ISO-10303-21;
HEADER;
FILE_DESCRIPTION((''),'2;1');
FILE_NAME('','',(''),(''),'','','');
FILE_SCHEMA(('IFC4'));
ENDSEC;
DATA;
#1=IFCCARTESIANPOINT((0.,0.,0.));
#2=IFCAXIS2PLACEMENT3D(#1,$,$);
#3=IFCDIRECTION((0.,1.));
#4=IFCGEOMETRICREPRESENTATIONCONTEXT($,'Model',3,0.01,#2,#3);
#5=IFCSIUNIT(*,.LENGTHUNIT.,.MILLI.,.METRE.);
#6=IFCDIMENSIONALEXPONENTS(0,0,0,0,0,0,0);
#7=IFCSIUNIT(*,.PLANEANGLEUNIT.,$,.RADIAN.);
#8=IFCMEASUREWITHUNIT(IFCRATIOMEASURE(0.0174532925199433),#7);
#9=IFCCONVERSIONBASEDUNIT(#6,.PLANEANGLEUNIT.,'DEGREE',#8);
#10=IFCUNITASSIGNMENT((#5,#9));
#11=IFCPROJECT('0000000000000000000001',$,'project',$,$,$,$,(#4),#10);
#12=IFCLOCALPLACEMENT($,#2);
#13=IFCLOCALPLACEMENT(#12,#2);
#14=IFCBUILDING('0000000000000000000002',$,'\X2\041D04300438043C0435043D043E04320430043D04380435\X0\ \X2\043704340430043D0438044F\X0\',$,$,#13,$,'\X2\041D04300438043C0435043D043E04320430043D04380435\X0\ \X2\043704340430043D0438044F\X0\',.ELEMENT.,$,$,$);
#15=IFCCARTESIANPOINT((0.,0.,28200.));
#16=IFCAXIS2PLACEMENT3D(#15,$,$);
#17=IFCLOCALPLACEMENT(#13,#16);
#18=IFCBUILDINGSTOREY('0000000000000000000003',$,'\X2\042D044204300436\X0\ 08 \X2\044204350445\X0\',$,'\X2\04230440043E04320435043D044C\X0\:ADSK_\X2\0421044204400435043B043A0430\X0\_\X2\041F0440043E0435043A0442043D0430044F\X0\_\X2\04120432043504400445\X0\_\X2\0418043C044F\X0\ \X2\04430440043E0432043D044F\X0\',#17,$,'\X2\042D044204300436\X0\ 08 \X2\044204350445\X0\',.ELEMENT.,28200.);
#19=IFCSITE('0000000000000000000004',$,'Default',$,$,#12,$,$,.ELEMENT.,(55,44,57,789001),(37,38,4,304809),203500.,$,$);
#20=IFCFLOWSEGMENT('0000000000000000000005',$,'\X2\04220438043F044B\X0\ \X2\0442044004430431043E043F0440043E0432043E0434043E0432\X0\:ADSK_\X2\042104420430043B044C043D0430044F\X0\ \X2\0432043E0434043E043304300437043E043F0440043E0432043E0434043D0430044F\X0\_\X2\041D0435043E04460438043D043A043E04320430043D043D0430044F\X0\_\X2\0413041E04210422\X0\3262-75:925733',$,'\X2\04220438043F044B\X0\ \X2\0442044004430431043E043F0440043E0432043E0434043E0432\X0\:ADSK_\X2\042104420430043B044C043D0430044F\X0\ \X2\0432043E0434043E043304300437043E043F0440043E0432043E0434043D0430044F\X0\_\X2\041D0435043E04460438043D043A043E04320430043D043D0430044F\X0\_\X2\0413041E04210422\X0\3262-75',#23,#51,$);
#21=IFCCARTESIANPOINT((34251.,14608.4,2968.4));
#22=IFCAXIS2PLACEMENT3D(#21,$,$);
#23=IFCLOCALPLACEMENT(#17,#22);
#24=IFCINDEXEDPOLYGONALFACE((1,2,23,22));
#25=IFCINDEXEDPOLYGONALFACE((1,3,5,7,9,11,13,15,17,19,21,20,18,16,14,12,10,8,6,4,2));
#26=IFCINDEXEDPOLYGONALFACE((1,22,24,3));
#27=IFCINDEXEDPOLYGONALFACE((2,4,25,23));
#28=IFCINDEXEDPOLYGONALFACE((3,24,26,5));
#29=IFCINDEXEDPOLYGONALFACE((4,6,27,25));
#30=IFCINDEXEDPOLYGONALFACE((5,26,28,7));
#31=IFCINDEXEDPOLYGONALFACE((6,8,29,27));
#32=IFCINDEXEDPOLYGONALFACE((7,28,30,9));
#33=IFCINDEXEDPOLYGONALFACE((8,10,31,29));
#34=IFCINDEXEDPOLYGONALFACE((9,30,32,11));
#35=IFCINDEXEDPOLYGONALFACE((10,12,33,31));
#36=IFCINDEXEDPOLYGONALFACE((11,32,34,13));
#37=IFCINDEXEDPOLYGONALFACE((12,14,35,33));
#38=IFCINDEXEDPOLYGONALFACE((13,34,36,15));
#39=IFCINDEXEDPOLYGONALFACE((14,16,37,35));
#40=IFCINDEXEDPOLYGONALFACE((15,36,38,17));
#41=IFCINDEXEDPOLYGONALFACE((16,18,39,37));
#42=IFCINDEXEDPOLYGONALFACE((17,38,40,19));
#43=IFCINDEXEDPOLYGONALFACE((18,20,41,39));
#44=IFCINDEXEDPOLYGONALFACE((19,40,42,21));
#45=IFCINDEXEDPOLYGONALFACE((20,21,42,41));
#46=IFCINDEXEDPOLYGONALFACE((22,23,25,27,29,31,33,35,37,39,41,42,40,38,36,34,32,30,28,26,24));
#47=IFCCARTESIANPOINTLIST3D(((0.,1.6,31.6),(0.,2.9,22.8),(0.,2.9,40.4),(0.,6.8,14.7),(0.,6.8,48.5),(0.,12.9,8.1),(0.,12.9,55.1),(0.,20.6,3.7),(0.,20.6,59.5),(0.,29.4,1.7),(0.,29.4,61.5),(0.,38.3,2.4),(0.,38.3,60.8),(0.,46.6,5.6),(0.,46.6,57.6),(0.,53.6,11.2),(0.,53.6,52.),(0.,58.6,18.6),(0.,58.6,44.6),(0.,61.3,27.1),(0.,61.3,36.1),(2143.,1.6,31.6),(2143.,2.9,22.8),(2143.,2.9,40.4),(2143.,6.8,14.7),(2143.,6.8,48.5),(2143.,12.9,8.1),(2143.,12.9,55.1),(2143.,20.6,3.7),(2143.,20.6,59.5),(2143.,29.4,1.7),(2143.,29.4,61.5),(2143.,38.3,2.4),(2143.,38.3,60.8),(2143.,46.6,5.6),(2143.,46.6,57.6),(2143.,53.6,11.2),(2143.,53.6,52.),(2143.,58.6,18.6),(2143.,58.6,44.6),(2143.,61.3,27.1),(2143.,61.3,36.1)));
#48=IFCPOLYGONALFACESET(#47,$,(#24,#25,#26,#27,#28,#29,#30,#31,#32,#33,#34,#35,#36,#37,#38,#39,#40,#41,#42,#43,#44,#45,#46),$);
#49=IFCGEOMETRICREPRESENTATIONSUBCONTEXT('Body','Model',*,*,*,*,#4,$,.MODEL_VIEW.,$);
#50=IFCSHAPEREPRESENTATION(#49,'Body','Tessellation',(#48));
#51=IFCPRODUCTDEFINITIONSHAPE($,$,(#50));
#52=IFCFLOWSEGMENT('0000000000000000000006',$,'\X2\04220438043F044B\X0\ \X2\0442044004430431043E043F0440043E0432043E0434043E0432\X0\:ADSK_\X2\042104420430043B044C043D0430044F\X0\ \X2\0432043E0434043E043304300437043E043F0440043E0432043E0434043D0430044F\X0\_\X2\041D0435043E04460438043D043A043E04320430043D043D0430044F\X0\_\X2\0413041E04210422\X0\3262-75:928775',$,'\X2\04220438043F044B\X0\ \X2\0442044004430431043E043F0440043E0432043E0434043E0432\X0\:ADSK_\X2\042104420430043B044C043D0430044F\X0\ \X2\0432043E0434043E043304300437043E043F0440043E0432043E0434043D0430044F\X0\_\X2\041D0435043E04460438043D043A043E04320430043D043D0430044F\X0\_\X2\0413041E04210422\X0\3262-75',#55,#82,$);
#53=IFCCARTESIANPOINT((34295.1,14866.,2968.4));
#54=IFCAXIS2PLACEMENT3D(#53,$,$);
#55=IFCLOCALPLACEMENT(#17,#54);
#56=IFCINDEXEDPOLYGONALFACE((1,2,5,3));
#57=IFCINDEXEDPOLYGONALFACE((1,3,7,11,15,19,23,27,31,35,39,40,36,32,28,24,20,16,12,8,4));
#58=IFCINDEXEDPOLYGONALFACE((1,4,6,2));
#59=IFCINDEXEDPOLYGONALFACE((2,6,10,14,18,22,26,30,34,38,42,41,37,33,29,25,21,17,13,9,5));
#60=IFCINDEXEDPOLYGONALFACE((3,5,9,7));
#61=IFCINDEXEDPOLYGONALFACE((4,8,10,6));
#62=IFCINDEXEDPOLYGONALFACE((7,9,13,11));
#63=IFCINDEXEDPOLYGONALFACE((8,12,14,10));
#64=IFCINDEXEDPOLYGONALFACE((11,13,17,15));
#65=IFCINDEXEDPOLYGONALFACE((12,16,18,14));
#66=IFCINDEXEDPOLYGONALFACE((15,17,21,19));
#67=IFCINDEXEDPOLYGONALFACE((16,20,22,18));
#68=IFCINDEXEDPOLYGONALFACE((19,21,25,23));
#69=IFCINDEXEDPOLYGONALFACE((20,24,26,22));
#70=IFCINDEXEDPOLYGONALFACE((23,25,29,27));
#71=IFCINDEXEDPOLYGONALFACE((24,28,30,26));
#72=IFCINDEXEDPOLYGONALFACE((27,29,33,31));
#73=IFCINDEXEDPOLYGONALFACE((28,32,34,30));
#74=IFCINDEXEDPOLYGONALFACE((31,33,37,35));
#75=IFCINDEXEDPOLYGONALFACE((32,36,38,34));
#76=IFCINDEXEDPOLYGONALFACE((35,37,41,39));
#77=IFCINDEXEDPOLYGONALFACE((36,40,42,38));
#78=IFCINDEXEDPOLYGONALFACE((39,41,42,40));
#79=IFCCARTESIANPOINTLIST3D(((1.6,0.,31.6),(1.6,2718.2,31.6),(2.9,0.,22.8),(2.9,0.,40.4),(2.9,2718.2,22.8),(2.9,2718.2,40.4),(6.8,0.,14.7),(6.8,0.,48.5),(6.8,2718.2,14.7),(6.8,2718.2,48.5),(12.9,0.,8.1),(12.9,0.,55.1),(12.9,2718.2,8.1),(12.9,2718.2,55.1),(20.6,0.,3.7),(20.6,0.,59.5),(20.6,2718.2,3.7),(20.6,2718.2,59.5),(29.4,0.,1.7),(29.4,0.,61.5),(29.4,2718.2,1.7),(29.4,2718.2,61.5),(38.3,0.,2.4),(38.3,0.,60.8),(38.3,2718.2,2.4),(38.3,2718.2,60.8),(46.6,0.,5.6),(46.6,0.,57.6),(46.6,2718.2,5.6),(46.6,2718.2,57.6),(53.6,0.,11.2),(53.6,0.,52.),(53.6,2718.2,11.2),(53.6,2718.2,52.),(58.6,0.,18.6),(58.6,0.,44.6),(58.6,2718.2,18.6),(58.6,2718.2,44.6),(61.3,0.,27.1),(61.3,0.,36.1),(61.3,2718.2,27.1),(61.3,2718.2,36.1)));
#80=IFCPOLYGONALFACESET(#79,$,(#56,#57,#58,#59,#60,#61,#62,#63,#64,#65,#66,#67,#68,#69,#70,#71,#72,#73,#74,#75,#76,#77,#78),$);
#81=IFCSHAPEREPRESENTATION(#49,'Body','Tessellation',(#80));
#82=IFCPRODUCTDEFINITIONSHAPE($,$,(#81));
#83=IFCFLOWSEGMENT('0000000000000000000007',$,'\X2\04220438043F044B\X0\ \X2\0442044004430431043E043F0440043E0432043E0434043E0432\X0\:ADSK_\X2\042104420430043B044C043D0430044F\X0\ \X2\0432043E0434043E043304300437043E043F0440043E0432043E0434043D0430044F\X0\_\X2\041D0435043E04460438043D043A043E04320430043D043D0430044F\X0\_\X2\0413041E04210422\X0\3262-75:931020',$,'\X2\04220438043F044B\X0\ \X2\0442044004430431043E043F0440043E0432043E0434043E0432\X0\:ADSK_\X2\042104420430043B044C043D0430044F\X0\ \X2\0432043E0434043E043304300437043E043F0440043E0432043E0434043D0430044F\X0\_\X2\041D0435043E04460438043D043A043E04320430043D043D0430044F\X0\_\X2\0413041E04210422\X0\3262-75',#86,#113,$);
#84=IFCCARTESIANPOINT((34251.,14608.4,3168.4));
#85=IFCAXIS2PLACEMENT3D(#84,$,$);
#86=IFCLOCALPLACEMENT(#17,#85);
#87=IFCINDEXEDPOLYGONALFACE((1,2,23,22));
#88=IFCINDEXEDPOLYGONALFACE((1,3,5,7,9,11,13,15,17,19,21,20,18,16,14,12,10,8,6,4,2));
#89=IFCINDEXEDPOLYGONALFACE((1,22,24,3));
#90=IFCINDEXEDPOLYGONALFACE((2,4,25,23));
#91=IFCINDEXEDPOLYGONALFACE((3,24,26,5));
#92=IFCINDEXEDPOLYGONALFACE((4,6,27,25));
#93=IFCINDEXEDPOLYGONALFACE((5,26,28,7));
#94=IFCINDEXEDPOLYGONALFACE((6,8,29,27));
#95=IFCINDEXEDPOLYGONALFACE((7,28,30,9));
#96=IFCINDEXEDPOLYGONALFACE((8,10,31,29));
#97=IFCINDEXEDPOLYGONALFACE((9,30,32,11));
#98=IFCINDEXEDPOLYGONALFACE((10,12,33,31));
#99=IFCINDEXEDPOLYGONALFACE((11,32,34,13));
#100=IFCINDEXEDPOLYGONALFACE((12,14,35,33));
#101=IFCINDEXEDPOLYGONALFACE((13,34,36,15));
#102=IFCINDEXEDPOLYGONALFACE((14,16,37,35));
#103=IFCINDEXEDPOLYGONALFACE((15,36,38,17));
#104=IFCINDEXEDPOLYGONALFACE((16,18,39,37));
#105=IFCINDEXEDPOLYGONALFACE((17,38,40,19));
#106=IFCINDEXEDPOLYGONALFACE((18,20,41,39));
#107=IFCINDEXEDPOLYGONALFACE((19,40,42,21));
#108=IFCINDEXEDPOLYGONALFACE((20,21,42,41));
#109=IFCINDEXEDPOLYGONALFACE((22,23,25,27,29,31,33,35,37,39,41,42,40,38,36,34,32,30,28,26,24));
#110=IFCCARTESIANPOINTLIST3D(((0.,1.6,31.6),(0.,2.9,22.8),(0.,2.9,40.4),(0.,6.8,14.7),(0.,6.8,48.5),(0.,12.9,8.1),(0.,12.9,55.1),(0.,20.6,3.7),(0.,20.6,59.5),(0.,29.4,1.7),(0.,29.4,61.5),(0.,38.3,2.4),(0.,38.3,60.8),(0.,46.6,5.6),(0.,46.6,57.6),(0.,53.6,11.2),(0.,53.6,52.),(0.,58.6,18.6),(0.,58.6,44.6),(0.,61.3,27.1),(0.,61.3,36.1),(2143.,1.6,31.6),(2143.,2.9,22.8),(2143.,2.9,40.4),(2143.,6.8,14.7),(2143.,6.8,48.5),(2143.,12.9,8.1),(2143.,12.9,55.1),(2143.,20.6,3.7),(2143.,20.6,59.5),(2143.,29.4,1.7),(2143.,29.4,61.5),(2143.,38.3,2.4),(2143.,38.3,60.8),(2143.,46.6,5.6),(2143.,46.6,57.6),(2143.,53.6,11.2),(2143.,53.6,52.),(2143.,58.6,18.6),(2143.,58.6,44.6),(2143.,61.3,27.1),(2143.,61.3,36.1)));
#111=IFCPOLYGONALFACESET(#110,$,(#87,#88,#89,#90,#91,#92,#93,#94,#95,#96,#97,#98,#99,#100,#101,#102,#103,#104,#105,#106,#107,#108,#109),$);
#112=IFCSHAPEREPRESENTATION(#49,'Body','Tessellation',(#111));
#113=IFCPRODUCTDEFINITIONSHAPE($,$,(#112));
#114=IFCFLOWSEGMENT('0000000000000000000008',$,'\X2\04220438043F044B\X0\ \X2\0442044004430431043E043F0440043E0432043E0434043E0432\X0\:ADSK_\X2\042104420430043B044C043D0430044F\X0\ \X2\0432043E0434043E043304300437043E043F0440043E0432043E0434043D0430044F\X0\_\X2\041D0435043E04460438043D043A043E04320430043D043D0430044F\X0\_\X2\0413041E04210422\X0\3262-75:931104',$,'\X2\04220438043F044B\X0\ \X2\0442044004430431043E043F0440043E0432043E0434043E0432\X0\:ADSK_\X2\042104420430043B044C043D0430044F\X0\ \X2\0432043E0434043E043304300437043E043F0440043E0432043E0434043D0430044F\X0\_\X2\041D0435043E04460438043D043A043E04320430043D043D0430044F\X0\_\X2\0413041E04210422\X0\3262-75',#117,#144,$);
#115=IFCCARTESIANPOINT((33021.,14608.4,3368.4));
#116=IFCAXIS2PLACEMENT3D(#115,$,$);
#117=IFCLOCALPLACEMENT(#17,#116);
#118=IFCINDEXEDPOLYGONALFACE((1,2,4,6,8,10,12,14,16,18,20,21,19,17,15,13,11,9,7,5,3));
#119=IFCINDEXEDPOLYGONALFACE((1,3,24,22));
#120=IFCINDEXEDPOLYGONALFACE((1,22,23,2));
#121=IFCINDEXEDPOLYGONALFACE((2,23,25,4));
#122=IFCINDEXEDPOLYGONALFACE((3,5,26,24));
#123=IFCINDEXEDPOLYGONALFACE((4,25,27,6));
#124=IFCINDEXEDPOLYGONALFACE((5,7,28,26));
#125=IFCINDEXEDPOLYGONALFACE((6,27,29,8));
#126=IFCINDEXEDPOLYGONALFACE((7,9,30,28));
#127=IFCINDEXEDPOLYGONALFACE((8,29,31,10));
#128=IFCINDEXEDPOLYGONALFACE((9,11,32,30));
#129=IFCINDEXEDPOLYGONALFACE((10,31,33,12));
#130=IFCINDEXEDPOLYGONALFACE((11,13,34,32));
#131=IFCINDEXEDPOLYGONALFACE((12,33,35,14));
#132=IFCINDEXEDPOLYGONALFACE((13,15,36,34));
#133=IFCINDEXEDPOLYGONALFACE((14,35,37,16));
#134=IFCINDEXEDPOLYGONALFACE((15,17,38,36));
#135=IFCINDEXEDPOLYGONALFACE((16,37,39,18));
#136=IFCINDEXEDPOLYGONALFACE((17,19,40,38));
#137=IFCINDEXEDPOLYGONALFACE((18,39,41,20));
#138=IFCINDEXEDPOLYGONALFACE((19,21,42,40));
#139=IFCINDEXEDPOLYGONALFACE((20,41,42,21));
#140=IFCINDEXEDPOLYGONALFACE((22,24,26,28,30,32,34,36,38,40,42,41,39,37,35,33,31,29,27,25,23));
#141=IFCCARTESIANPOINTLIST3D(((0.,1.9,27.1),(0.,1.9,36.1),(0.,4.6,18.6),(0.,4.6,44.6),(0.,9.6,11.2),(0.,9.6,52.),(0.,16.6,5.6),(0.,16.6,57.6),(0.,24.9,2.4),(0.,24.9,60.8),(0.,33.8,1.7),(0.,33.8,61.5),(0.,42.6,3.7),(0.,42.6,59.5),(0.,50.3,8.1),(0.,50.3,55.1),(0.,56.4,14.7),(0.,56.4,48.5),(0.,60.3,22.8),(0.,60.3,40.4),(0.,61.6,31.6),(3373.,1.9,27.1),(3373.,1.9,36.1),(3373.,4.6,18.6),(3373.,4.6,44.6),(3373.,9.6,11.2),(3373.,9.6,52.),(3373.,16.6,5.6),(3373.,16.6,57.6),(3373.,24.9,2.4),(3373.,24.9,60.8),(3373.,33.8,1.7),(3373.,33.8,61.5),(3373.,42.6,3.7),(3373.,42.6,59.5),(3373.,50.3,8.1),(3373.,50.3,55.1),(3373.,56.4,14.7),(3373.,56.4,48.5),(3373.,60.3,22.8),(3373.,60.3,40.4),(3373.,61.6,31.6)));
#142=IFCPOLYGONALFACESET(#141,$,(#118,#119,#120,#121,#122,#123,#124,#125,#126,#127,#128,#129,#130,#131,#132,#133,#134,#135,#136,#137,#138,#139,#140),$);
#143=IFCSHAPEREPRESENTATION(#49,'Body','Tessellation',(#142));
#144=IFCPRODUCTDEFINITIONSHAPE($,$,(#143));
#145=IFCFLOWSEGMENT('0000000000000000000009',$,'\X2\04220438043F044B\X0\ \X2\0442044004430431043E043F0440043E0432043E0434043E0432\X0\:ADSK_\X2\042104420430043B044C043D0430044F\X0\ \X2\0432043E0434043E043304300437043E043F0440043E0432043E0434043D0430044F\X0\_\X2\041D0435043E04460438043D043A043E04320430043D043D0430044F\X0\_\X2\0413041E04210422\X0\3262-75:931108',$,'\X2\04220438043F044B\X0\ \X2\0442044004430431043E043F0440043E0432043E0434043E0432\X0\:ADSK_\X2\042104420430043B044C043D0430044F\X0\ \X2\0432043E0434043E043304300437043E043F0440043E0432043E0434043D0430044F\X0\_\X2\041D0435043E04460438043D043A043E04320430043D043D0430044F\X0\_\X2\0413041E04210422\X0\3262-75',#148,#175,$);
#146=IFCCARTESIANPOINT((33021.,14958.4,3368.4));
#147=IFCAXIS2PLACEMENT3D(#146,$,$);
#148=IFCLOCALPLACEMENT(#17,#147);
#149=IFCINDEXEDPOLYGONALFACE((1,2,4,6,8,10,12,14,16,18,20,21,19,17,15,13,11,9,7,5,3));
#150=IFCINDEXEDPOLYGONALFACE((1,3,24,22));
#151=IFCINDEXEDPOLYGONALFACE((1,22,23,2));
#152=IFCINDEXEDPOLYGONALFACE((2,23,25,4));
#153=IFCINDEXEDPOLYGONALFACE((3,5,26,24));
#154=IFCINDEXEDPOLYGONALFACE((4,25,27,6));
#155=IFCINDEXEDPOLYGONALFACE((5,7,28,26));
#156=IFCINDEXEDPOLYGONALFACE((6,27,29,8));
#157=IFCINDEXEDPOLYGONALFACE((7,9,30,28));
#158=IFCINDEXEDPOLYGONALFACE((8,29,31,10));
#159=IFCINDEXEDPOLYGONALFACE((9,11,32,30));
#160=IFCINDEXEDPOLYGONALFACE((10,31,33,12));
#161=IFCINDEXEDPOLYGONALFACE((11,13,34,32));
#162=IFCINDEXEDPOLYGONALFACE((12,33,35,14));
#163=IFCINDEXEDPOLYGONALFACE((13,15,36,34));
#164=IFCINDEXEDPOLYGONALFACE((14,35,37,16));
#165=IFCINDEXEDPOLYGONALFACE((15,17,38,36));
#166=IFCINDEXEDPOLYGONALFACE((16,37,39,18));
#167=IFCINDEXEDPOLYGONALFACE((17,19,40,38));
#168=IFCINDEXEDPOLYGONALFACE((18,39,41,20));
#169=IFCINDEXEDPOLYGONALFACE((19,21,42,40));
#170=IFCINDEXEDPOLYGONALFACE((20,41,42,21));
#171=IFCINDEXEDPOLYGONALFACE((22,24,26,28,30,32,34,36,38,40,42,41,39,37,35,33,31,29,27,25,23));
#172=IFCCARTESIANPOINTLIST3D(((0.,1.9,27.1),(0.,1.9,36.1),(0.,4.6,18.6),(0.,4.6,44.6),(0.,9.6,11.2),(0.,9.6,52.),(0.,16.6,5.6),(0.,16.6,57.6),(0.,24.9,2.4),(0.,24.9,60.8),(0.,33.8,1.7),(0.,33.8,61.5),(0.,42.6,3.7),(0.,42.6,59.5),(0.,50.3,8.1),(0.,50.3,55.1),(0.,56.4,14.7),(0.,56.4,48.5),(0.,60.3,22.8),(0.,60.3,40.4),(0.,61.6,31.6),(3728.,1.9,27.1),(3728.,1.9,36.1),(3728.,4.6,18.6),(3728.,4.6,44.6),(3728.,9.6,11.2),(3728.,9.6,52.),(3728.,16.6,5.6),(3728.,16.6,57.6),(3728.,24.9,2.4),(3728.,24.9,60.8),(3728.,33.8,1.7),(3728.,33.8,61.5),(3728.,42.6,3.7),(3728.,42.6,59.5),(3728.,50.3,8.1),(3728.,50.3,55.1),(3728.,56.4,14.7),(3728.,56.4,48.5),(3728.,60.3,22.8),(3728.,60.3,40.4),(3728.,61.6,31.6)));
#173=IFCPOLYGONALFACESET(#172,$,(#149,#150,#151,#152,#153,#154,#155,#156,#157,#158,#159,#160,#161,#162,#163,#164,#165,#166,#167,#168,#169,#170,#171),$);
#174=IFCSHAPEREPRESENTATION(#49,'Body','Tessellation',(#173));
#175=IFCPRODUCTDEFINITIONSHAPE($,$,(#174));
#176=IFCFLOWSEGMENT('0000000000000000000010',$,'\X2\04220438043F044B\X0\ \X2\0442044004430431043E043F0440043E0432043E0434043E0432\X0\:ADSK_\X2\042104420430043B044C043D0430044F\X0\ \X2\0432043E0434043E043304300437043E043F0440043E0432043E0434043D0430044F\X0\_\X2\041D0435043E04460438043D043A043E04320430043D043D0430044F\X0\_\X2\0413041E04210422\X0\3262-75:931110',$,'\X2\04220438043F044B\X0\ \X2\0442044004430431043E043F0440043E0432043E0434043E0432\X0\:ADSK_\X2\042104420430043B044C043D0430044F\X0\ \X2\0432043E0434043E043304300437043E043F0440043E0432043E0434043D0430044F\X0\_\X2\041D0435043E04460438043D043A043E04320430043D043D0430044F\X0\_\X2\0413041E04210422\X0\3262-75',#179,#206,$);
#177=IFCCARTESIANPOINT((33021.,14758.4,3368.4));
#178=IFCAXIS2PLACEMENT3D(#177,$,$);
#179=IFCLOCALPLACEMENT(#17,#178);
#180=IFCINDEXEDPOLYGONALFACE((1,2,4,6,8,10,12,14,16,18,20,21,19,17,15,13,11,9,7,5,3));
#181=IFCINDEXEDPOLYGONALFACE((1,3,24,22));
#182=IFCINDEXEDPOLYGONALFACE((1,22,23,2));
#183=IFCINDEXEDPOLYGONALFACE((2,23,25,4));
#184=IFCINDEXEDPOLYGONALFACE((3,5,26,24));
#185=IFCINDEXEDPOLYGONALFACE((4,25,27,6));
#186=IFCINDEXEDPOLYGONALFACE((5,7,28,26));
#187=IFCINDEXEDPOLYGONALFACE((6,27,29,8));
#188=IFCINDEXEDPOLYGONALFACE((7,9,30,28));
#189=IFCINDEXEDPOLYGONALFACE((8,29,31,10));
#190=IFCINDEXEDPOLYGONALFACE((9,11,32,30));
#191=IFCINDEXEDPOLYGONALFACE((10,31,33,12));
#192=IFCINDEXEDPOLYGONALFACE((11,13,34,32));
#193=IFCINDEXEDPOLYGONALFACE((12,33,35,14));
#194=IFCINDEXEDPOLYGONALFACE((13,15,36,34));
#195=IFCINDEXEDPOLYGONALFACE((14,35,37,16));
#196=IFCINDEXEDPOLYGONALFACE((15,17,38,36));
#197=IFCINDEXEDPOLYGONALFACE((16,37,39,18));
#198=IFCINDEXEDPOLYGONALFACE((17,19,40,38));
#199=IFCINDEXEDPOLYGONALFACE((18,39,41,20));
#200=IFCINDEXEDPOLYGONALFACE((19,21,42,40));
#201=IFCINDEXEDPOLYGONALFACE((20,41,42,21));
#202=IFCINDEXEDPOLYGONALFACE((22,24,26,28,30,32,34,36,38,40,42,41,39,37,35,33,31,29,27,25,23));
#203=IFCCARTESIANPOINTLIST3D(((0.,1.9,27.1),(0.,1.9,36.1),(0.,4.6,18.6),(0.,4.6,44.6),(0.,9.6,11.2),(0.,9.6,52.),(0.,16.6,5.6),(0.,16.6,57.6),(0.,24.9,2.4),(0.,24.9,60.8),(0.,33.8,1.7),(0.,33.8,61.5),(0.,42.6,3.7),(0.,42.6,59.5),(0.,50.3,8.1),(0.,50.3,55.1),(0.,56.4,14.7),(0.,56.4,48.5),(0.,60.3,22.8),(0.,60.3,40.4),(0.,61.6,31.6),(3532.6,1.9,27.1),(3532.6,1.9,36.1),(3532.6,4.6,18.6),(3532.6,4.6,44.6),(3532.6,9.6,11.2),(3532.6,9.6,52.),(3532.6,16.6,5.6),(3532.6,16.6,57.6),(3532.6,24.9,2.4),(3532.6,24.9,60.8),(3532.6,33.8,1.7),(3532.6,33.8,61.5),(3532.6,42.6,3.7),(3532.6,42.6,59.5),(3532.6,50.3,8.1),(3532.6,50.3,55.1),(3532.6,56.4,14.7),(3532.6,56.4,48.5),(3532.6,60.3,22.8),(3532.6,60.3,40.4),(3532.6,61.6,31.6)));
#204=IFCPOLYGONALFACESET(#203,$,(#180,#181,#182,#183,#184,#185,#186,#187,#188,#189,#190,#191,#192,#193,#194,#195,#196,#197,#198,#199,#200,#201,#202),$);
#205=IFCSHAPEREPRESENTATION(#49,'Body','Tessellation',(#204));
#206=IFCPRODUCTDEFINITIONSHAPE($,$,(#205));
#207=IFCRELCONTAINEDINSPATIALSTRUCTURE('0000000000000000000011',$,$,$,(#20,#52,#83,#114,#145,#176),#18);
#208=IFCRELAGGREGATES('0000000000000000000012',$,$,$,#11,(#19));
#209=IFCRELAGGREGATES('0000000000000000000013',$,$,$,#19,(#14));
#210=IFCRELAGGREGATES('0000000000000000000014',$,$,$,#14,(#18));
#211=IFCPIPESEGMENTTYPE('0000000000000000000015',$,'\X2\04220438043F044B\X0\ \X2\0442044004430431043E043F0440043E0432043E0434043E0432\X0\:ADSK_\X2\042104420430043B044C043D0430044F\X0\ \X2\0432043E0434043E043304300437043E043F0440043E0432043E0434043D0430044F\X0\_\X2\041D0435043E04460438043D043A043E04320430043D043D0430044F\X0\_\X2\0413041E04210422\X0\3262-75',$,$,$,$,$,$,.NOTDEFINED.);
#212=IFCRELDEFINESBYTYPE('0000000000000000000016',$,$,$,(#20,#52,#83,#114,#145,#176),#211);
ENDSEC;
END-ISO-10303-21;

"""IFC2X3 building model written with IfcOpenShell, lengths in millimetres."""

from ifc_helpers import new_model, entity, si_unit, converted_unit, direction, frame, origin, origin_2d_with_axis, place, context, subcontext, project, spatial, circle, extrude, type_object, element, save


model = new_model("IFC2X3")

# Units and contexts
model_context = context("Model", 3, precision=0.01, world=origin(), true_north=direction((0.0, 1.0)))
body_context = subcontext(model_context, "Body", "Model", "MODEL_VIEW")
ifc_project = project(units=[si_unit("LENGTHUNIT", "METRE", prefix="MILLI"), converted_unit("PLANEANGLEUNIT", "DEGREE", entity("IfcRatioMeasure", 0.0174532925199433), si_unit("PLANEANGLEUNIT", "RADIAN"), dimensions=[0, 0, 0, 0, 0, 0, 0])], contexts=[model_context])

# Site, building, storey
site_placement = place(None, origin())
site = spatial("IfcSite", under=ifc_project, at=site_placement, Name="Default", CompositionType="ELEMENT", RefLatitude=(55, 44, 57, 789001), RefLongitude=(37, 38, 4, 304809), RefElevation=203500.0)
building_placement = place(site_placement, origin())
building = spatial("IfcBuilding", under=site, at=building_placement, Name="Наименование здания", LongName="Наименование здания", CompositionType="ELEMENT")
storey_placement = place(building_placement, frame((0.0, 0.0, 28200.0)))
storey = spatial("IfcBuildingStorey", under=building, at=storey_placement, Name="Этаж 08 тех", ObjectType="Уровень:ADSK_Стрелка_Проектная_Вверх_Имя уровня", LongName="Этаж 08 тех", CompositionType="ELEMENT", Elevation=28200.0)

# Flow segments
pipe_segment_type = type_object("IfcPipeSegmentType", Name="Типы трубопроводов:ADSK_Стальная водогазопроводная_Неоцинкованная_ГОСТ3262-75", PredefinedType="NOTDEFINED")
flow_segment_1_placement = place(storey_placement, frame((34251.0, 14608.4, 2968.4)))
element("IfcFlowSegment", 1, at=flow_segment_1_placement, inside=storey, type_object=pipe_segment_type, Name="Типы трубопроводов:ADSK_Стальная водогазопроводная_Неоцинкованная_ГОСТ3262-75:925733", ObjectType="Типы трубопроводов:ADSK_Стальная водогазопроводная_Неоцинкованная_ГОСТ3262-75", context=body_context, shape_type="SweptSolid", body=[
    extrude(circle(Radius=30.0, at=origin_2d_with_axis()), frame((0.0, 31.6, 31.6), z_axis=(1.0, 0.0, 0.0), x_axis=(0.0, -1.0, 0.0)), (0.0, 0.0, 1.0), 2143.0),
])
flow_segment_2_placement = place(storey_placement, frame((34295.1, 14866.0, 2968.4)))
element("IfcFlowSegment", 2, at=flow_segment_2_placement, inside=storey, type_object=pipe_segment_type, Name="Типы трубопроводов:ADSK_Стальная водогазопроводная_Неоцинкованная_ГОСТ3262-75:928775", ObjectType="Типы трубопроводов:ADSK_Стальная водогазопроводная_Неоцинкованная_ГОСТ3262-75", context=body_context, shape_type="SweptSolid", body=[
    extrude(circle(Radius=30.0, at=origin_2d_with_axis()), frame((31.6, 0.0, 31.6), z_axis=(0.0, 1.0, 0.0), x_axis=(-1.0, 0.0, 0.0)), (0.0, 0.0, 1.0), 2718.2),
])
flow_segment_3_placement = place(storey_placement, frame((34251.0, 14608.4, 3168.4)))
element("IfcFlowSegment", 3, at=flow_segment_3_placement, inside=storey, type_object=pipe_segment_type, Name="Типы трубопроводов:ADSK_Стальная водогазопроводная_Неоцинкованная_ГОСТ3262-75:931020", ObjectType="Типы трубопроводов:ADSK_Стальная водогазопроводная_Неоцинкованная_ГОСТ3262-75", context=body_context, shape_type="SweptSolid", body=[
    extrude(circle(Radius=30.0, at=origin_2d_with_axis()), frame((0.0, 31.6, 31.6), z_axis=(1.0, 0.0, 0.0), x_axis=(0.0, -1.0, 0.0)), (0.0, 0.0, 1.0), 2143.0),
])
flow_segment_4_placement = place(storey_placement, frame((33021.0, 14608.4, 3368.4)))
element("IfcFlowSegment", 4, at=flow_segment_4_placement, inside=storey, type_object=pipe_segment_type, Name="Типы трубопроводов:ADSK_Стальная водогазопроводная_Неоцинкованная_ГОСТ3262-75:931104", ObjectType="Типы трубопроводов:ADSK_Стальная водогазопроводная_Неоцинкованная_ГОСТ3262-75", context=body_context, shape_type="SweptSolid", body=[
    extrude(circle(Radius=30.0, at=origin_2d_with_axis()), frame((0.0, 31.6, 31.6), z_axis=(1.0, 0.0, 0.0), x_axis=(0.0, 1.0, 0.0)), (0.0, 0.0, 1.0), 3373.0),
])
flow_segment_5_placement = place(storey_placement, frame((33021.0, 14958.4, 3368.4)))
element("IfcFlowSegment", 5, at=flow_segment_5_placement, inside=storey, type_object=pipe_segment_type, Name="Типы трубопроводов:ADSK_Стальная водогазопроводная_Неоцинкованная_ГОСТ3262-75:931108", ObjectType="Типы трубопроводов:ADSK_Стальная водогазопроводная_Неоцинкованная_ГОСТ3262-75", context=body_context, shape_type="SweptSolid", body=[
    extrude(circle(Radius=30.0, at=origin_2d_with_axis()), frame((0.0, 31.6, 31.6), z_axis=(1.0, 0.0, 0.0), x_axis=(0.0, 1.0, 0.0)), (0.0, 0.0, 1.0), 3728.0),
])
flow_segment_6_placement = place(storey_placement, frame((33021.0, 14758.4, 3368.4)))
element("IfcFlowSegment", 6, at=flow_segment_6_placement, inside=storey, type_object=pipe_segment_type, Name="Типы трубопроводов:ADSK_Стальная водогазопроводная_Неоцинкованная_ГОСТ3262-75:931110", ObjectType="Типы трубопроводов:ADSK_Стальная водогазопроводная_Неоцинкованная_ГОСТ3262-75", context=body_context, shape_type="SweptSolid", body=[
    extrude(circle(Radius=30.0, at=origin_2d_with_axis()), frame((0.0, 31.6, 31.6), z_axis=(1.0, 0.0, 0.0), x_axis=(0.0, 1.0, 0.0)), (0.0, 0.0, 1.0), 3532.6),
])

save(model, "model.ifc")
